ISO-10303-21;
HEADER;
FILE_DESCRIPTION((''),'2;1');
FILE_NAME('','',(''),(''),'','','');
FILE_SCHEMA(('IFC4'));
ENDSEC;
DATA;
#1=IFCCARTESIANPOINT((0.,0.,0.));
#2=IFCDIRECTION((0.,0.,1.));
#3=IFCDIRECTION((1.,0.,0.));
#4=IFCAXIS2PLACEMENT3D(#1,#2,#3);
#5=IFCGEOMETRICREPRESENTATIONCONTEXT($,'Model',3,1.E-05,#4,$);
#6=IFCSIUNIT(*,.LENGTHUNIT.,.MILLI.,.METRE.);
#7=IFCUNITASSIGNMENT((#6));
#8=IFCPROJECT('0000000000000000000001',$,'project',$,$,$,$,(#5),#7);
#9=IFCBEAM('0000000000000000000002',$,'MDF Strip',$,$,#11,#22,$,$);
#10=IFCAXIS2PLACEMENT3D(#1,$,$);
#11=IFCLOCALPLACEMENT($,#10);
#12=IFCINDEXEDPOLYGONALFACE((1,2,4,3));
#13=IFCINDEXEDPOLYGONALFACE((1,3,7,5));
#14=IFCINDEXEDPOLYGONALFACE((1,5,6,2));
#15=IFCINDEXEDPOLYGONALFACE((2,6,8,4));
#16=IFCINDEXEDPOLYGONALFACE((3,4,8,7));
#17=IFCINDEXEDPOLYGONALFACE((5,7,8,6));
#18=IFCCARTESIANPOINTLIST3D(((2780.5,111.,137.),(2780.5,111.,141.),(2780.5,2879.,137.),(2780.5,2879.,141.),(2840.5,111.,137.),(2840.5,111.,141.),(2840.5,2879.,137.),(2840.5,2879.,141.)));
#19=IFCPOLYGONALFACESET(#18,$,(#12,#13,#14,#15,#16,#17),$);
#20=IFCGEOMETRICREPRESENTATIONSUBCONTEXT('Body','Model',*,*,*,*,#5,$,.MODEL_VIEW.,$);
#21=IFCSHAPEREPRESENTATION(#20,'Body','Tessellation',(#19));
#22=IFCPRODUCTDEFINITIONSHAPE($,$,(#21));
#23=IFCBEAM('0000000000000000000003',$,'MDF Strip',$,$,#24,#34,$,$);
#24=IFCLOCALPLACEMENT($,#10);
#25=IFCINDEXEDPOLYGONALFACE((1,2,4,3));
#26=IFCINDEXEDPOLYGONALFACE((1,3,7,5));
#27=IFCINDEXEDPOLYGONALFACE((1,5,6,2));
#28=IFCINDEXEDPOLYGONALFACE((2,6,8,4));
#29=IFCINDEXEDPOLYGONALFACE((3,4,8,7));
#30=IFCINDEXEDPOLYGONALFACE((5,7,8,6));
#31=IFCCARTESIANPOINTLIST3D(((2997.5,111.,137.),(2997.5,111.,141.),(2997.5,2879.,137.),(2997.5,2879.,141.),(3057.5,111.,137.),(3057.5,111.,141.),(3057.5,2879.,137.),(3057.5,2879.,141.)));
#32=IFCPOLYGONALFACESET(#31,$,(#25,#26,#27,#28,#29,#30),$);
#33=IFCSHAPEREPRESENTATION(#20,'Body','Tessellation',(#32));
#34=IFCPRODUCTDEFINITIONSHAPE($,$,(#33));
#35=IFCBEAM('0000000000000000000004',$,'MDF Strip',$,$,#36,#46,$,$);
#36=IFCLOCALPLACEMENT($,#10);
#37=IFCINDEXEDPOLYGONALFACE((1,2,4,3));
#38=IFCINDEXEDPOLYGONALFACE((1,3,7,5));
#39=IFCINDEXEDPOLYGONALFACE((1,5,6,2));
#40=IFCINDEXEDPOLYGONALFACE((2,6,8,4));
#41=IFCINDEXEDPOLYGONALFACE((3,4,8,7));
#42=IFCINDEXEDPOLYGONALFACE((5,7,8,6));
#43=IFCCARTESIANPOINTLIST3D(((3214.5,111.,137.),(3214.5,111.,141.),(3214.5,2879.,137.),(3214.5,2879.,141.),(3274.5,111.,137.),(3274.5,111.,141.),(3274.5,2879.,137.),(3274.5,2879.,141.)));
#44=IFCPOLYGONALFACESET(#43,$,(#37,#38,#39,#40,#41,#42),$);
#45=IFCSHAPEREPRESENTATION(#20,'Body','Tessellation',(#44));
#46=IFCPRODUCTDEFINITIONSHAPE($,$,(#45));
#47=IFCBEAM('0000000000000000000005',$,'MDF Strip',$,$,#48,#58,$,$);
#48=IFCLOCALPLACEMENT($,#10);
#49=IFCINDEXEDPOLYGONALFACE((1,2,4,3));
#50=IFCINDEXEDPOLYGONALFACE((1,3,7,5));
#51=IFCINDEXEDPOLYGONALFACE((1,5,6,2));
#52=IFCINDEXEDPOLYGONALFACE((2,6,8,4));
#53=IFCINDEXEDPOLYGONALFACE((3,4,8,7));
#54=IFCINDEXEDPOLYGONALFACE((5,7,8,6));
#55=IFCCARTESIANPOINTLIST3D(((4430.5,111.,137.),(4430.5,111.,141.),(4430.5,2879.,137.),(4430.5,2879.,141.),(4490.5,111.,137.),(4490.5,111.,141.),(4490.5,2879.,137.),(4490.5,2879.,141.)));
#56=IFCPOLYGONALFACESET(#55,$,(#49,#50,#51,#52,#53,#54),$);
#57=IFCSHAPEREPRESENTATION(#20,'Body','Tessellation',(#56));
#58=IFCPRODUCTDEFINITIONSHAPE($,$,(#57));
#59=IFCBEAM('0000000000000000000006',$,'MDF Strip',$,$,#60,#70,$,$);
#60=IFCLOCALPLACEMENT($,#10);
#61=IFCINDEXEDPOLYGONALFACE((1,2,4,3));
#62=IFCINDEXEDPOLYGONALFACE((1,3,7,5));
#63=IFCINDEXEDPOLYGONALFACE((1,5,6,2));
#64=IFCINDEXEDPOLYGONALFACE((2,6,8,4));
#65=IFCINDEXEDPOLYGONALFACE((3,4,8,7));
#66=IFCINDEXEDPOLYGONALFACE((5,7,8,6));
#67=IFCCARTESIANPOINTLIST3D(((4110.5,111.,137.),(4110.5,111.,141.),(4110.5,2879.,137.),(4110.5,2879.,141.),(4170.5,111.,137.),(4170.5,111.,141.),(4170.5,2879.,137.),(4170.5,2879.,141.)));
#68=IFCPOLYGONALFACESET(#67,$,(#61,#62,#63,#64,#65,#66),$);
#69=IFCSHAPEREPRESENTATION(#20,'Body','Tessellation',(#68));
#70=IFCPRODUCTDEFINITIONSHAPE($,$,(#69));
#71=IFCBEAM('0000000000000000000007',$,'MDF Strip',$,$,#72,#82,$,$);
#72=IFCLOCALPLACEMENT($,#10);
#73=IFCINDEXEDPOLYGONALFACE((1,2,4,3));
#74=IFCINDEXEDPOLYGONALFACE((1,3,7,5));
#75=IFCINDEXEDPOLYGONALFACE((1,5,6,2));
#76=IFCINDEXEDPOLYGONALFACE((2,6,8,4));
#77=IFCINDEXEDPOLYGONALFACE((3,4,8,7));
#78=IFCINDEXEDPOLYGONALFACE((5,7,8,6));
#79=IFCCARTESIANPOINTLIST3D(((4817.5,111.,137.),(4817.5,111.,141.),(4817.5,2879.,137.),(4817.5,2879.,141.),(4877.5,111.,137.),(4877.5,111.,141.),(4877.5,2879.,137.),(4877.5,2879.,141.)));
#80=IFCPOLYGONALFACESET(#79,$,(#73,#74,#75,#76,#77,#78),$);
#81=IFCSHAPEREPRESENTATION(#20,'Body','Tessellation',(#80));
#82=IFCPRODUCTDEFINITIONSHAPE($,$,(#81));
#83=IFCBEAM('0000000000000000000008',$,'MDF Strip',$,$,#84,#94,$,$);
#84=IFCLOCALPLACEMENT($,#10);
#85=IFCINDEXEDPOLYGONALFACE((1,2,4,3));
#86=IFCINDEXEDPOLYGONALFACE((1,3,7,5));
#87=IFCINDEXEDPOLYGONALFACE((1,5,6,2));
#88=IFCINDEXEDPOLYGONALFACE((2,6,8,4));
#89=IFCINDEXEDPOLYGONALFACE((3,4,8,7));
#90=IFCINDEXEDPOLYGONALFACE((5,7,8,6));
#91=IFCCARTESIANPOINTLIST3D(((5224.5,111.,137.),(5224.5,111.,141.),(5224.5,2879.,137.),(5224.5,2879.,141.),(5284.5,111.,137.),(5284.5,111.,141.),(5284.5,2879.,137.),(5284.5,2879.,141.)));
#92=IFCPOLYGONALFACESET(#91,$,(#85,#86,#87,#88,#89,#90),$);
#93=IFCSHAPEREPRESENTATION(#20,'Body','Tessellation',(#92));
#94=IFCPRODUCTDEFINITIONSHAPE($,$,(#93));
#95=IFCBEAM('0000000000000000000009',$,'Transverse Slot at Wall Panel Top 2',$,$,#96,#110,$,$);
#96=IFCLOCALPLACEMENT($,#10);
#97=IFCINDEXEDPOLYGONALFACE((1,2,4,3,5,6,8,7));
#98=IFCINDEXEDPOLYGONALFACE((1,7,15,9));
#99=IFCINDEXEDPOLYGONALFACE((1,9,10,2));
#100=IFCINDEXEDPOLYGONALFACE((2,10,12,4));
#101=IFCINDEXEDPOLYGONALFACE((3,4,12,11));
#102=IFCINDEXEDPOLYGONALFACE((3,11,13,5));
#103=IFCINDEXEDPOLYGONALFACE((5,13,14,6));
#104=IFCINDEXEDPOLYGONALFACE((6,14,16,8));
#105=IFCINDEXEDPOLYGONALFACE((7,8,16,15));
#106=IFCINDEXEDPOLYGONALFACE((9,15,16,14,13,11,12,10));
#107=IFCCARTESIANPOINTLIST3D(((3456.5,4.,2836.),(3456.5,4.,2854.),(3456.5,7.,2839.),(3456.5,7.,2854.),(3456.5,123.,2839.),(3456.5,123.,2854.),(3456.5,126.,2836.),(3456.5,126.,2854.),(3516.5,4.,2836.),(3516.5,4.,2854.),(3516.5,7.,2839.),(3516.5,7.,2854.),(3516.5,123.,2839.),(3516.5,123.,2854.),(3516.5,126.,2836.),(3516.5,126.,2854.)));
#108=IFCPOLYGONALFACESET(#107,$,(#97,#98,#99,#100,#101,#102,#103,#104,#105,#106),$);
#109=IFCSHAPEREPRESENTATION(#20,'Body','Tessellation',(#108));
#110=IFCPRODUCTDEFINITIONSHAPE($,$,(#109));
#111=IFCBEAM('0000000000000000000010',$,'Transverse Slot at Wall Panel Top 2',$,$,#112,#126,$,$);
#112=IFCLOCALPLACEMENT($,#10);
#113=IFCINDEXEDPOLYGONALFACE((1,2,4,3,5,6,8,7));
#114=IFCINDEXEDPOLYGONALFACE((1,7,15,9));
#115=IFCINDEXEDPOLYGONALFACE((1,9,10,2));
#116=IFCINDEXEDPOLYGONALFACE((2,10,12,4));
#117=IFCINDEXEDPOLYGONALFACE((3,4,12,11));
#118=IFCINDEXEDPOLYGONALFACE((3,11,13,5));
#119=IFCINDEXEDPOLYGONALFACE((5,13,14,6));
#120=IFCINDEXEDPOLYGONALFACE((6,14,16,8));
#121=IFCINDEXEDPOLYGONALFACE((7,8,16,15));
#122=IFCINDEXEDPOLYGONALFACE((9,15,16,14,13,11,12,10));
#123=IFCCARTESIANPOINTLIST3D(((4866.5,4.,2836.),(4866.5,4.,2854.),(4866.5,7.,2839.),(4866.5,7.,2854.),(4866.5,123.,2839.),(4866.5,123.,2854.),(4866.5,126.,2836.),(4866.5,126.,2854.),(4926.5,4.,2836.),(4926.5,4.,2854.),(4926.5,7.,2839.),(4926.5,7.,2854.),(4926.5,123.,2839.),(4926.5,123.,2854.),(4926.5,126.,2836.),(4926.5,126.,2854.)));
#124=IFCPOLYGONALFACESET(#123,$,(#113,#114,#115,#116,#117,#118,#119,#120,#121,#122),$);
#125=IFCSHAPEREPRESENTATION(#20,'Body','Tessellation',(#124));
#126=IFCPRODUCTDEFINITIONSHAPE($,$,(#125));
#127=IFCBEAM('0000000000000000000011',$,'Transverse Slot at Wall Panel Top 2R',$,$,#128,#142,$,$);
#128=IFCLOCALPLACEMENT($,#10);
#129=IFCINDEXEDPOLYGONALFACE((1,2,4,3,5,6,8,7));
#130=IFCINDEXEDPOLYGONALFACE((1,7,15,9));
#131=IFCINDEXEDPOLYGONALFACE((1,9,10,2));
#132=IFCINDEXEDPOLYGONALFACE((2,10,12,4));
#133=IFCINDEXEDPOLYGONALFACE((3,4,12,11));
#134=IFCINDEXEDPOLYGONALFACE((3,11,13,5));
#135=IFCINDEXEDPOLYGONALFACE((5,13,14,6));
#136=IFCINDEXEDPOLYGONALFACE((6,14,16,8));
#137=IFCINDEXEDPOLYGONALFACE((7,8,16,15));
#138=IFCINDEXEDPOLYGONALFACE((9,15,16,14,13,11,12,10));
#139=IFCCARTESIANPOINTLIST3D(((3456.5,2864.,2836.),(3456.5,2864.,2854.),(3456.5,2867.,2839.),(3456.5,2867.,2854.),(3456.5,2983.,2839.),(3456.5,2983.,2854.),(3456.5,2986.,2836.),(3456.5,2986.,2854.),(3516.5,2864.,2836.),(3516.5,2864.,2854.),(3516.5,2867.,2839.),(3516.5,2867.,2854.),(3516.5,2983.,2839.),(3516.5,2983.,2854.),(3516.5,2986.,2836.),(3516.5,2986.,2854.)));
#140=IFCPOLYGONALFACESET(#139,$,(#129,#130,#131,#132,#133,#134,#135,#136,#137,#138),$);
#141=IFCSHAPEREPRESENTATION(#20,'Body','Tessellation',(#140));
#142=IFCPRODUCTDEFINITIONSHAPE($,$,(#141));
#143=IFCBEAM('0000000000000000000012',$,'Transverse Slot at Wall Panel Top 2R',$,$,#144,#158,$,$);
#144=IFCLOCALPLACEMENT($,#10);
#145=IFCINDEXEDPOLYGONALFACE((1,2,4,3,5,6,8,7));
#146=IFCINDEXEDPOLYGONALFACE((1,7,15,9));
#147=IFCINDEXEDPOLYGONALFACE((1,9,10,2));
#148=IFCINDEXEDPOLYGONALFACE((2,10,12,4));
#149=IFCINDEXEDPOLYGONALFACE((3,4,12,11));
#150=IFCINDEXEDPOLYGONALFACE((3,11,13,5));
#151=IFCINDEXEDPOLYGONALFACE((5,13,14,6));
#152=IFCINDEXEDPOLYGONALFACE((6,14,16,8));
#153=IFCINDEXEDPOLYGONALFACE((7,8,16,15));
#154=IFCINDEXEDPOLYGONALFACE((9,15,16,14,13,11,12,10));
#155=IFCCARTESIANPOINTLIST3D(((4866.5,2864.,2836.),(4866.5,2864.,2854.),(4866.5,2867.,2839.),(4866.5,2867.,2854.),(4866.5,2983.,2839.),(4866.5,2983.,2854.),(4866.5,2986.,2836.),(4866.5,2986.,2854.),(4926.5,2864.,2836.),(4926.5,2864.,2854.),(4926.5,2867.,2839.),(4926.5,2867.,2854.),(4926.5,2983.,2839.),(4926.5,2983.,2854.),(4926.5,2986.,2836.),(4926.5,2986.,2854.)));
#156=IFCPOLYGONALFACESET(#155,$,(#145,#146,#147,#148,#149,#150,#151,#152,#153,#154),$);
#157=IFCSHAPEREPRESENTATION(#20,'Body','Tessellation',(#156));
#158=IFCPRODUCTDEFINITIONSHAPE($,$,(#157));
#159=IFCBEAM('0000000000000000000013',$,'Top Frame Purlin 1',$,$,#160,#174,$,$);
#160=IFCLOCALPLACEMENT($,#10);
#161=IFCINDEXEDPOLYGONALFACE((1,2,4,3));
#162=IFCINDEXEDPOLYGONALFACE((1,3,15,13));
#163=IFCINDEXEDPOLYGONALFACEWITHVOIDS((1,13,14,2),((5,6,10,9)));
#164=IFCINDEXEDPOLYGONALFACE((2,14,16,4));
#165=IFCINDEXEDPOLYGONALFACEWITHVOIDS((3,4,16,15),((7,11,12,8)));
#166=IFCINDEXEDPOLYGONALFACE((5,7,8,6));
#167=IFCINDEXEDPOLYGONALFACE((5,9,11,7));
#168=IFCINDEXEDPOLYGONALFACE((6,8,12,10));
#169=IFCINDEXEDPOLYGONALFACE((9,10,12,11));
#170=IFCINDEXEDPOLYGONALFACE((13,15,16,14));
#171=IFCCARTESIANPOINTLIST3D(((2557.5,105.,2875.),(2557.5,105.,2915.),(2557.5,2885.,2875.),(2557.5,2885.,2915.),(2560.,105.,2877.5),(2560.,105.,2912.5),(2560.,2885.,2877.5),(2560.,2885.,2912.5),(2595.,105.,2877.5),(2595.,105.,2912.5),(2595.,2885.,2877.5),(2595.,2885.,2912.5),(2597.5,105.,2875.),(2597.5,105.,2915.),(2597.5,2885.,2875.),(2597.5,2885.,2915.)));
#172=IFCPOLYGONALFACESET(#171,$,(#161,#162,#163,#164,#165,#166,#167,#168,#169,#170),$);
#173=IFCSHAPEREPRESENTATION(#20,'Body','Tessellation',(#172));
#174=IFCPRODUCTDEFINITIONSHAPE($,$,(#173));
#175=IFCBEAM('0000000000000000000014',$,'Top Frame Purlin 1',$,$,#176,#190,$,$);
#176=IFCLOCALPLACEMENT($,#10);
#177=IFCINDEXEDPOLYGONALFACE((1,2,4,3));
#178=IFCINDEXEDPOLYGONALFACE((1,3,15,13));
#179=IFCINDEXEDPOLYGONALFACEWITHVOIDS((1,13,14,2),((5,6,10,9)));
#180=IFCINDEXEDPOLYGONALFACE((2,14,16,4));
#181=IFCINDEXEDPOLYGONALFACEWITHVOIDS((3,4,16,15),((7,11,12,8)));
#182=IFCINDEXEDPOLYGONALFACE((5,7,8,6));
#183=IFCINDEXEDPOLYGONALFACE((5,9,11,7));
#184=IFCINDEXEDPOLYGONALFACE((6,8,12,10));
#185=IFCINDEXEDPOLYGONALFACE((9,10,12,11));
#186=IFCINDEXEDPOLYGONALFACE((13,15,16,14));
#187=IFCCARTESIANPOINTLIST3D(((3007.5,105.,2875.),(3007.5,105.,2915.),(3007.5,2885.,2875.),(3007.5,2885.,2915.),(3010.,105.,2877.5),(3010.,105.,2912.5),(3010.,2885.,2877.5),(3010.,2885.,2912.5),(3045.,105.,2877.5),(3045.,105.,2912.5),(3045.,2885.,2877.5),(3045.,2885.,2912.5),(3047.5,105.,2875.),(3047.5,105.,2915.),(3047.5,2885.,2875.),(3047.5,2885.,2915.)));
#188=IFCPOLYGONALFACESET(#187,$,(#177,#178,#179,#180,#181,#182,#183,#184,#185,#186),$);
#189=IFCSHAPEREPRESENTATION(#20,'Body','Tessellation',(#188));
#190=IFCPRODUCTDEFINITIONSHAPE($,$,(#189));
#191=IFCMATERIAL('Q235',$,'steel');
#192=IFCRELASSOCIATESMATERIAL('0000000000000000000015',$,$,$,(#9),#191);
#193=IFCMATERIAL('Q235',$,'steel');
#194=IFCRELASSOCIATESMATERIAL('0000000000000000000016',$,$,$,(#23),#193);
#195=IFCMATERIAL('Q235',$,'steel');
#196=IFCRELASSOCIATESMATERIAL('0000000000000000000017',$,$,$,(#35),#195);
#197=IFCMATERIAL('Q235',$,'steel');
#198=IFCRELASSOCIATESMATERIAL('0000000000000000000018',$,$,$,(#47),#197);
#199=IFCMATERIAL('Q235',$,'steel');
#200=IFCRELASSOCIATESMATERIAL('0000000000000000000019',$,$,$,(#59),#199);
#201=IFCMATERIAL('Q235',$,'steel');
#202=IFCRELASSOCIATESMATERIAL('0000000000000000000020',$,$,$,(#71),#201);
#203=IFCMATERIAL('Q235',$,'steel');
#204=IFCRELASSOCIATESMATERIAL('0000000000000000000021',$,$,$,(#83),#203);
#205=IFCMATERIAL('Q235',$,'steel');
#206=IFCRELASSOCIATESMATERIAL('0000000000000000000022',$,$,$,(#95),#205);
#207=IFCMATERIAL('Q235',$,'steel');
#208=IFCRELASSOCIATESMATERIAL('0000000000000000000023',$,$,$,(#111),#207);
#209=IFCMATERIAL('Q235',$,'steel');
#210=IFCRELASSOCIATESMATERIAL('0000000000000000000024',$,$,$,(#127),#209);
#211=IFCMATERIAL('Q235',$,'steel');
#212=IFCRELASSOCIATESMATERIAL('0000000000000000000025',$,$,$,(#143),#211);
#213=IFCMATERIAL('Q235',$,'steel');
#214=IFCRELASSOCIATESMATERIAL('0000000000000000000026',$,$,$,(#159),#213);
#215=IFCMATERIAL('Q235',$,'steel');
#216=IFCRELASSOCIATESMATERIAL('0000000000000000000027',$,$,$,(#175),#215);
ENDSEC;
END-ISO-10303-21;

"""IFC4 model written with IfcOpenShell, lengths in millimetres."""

from ifc_helpers import new_model, si_unit, frame, origin_with_axes, place, context, subcontext, project, line, indexed_curve, outline, extrude, material, element, save


model = new_model("IFC4")

# Units and contexts
model_context = context("Model", 3, precision=1e-05, world=origin_with_axes())
body_context = subcontext(model_context, "Body", "Model", "MODEL_VIEW")
ifc_project = project(units=[si_unit("LENGTHUNIT", "METRE", prefix="MILLI")], contexts=[model_context])

# Beams
ifc_material_1 = material(Name="Q235", Category="steel")
beam_1_placement = place(None, frame((2780.5, 111.0, 137.0), z_axis=(0.0, 1.0, 0.0), x_axis=(1.0, 0.0, 0.0)))
element("IfcBeam", 1, at=beam_1_placement, material=ifc_material_1, Name="MDF Strip", context=body_context, shape_type="SweptSolid", body=[
    extrude(outline(indexed_curve([(0.0, 0.0), (60.0, 0.0), (60.0, -4.0), (0.0, -4.0), (0.0, 0.0)], segments=[line(1, 2, 3, 4, 5, 1)])), origin_with_axes(), (0.0, 0.0, 1.0), 2768.0),
])
ifc_material_2 = material(Name="Q235", Category="steel")
beam_2_placement = place(None, frame((2997.5, 111.0, 137.0), z_axis=(0.0, 1.0, 0.0), x_axis=(1.0, 0.0, 0.0)))
element("IfcBeam", 2, at=beam_2_placement, material=ifc_material_2, Name="MDF Strip", context=body_context, shape_type="SweptSolid", body=[
    extrude(outline(indexed_curve([(0.0, 0.0), (60.0, 0.0), (60.0, -4.0), (0.0, -4.0), (0.0, 0.0)], segments=[line(1, 2, 3, 4, 5, 1)])), origin_with_axes(), (0.0, 0.0, 1.0), 2768.0),
])
ifc_material_3 = material(Name="Q235", Category="steel")
beam_3_placement = place(None, frame((3214.5, 111.0, 137.0), z_axis=(0.0, 1.0, 0.0), x_axis=(1.0, 0.0, 0.0)))
element("IfcBeam", 3, at=beam_3_placement, material=ifc_material_3, Name="MDF Strip", context=body_context, shape_type="SweptSolid", body=[
    extrude(outline(indexed_curve([(0.0, 0.0), (60.0, 0.0), (60.0, -4.0), (0.0, -4.0), (0.0, 0.0)], segments=[line(1, 2, 3, 4, 5, 1)])), origin_with_axes(), (0.0, 0.0, 1.0), 2768.0),
])
ifc_material_4 = material(Name="Q235", Category="steel")
beam_4_placement = place(None, frame((4430.5, 111.0, 137.0), z_axis=(0.0, 1.0, 0.0), x_axis=(1.0, 0.0, 0.0)))
element("IfcBeam", 4, at=beam_4_placement, material=ifc_material_4, Name="MDF Strip", context=body_context, shape_type="SweptSolid", body=[
    extrude(outline(indexed_curve([(0.0, 0.0), (60.0, 0.0), (60.0, -4.0), (0.0, -4.0), (0.0, 0.0)], segments=[line(1, 2, 3, 4, 5, 1)])), origin_with_axes(), (0.0, 0.0, 1.0), 2768.0),
])
ifc_material_5 = material(Name="Q235", Category="steel")
beam_5_placement = place(None, frame((4110.5, 111.0, 137.0), z_axis=(0.0, 1.0, 0.0), x_axis=(1.0, 0.0, 0.0)))
element("IfcBeam", 5, at=beam_5_placement, material=ifc_material_5, Name="MDF Strip", context=body_context, shape_type="SweptSolid", body=[
    extrude(outline(indexed_curve([(0.0, 0.0), (60.0, 0.0), (60.0, -4.0), (0.0, -4.0), (0.0, 0.0)], segments=[line(1, 2, 3, 4, 5, 1)])), origin_with_axes(), (0.0, 0.0, 1.0), 2768.0),
])
ifc_material_6 = material(Name="Q235", Category="steel")
beam_6_placement = place(None, frame((4817.5, 111.0, 137.0), z_axis=(0.0, 1.0, 0.0), x_axis=(1.0, 0.0, 0.0)))
element("IfcBeam", 6, at=beam_6_placement, material=ifc_material_6, Name="MDF Strip", context=body_context, shape_type="SweptSolid", body=[
    extrude(outline(indexed_curve([(0.0, 0.0), (60.0, 0.0), (60.0, -4.0), (0.0, -4.0), (0.0, 0.0)], segments=[line(1, 2, 3, 4, 5, 1)])), origin_with_axes(), (0.0, 0.0, 1.0), 2768.0),
])
ifc_material_7 = material(Name="Q235", Category="steel")
beam_7_placement = place(None, frame((5224.5, 111.0, 137.0), z_axis=(0.0, 1.0, 0.0), x_axis=(1.0, 0.0, 0.0)))
element("IfcBeam", 7, at=beam_7_placement, material=ifc_material_7, Name="MDF Strip", context=body_context, shape_type="SweptSolid", body=[
    extrude(outline(indexed_curve([(0.0, 0.0), (60.0, 0.0), (60.0, -4.0), (0.0, -4.0), (0.0, 0.0)], segments=[line(1, 2, 3, 4, 5, 1)])), origin_with_axes(), (0.0, 0.0, 1.0), 2768.0),
])
ifc_material_8 = material(Name="Q235", Category="steel")
beam_8_placement = place(None, frame((3456.5, 4.0, 2836.0), z_axis=(1.0, 0.0, 0.0), x_axis=(0.0, 0.0, -1.0)))
element("IfcBeam", 8, at=beam_8_placement, material=ifc_material_8, Name="Transverse Slot at Wall Panel Top 2", context=body_context, shape_type="SweptSolid", body=[
    extrude(outline(indexed_curve([(0.0, 0.0), (0.0, 122.0), (-18.0, 122.0), (-18.0, 119.0), (-3.0, 119.0), (-3.0, 3.0), (-18.0, 3.0), (-18.0, 0.0), (0.0, 0.0)], segments=[line(1, 2, 3, 4, 5, 6, 7, 8, 9, 1)])), origin_with_axes(), (0.0, 0.0, 1.0), 60.0),
])
ifc_material_9 = material(Name="Q235", Category="steel")
beam_9_placement = place(None, frame((4866.5, 4.0, 2836.0), z_axis=(1.0, 0.0, 0.0), x_axis=(0.0, 0.0, -1.0)))
element("IfcBeam", 9, at=beam_9_placement, material=ifc_material_9, Name="Transverse Slot at Wall Panel Top 2", context=body_context, shape_type="SweptSolid", body=[
    extrude(outline(indexed_curve([(0.0, 0.0), (0.0, 122.0), (-18.0, 122.0), (-18.0, 119.0), (-3.0, 119.0), (-3.0, 3.0), (-18.0, 3.0), (-18.0, 0.0), (0.0, 0.0)], segments=[line(1, 2, 3, 4, 5, 6, 7, 8, 9, 1)])), origin_with_axes(), (0.0, 0.0, 1.0), 60.0),
])
ifc_material_10 = material(Name="Q235", Category="steel")
beam_10_placement = place(None, frame((3456.5, 2986.0, 2836.0), z_axis=(1.0, 0.0, 0.0), x_axis=(0.0, 0.0, 1.0)))
element("IfcBeam", 10, at=beam_10_placement, material=ifc_material_10, Name="Transverse Slot at Wall Panel Top 2R", context=body_context, shape_type="SweptSolid", body=[
    extrude(outline(indexed_curve([(0.0, 0.0), (0.0, 122.0), (18.0, 122.0), (18.0, 119.0), (3.0, 119.0), (3.0, 3.0), (18.0, 3.0), (18.0, 0.0), (0.0, 0.0)], segments=[line(1, 2, 3, 4, 5, 6, 7, 8, 9, 1)])), origin_with_axes(), (0.0, 0.0, 1.0), 60.0),
])
ifc_material_11 = material(Name="Q235", Category="steel")
beam_11_placement = place(None, frame((4866.5, 2986.0, 2836.0), z_axis=(1.0, 0.0, 0.0), x_axis=(0.0, 0.0, 1.0)))
element("IfcBeam", 11, at=beam_11_placement, material=ifc_material_11, Name="Transverse Slot at Wall Panel Top 2R", context=body_context, shape_type="SweptSolid", body=[
    extrude(outline(indexed_curve([(0.0, 0.0), (0.0, 122.0), (18.0, 122.0), (18.0, 119.0), (3.0, 119.0), (3.0, 3.0), (18.0, 3.0), (18.0, 0.0), (0.0, 0.0)], segments=[line(1, 2, 3, 4, 5, 6, 7, 8, 9, 1)])), origin_with_axes(), (0.0, 0.0, 1.0), 60.0),
])

# Beams, openings
ifc_material_12 = material(Name="Q235", Category="steel")
beam_12_placement = place(None, frame((2557.5, 105.0, 2875.0), z_axis=(0.0, 1.0, 0.0), x_axis=(1.0, 0.0, 0.0)))
beam_12 = element("IfcBeam", 12, at=beam_12_placement, material=ifc_material_12, Name="Top Frame Purlin 1", context=body_context, shape_type="SweptSolid", body=[
    extrude(outline(indexed_curve([(0.0, 0.0), (0.0, -40.0), (40.0, -40.0), (40.0, 0.0), (0.0, 0.0)], segments=[line(1, 2, 3, 4, 5, 1)])), origin_with_axes(), (0.0, 0.0, 1.0), 2780.0),
])
opening_1_placement = place(beam_12_placement, frame((2.5, -2.5, 0.0), z_axis=(0.0, 0.0, 1.0), x_axis=(1.0, 0.0, 0.0)))
element("IfcOpeningElement", 13, at=opening_1_placement, cuts=beam_12, context=body_context, shape_type="SweptSolid", body=[
    extrude(outline(indexed_curve([(0.0, 0.0), (0.0, -35.0), (35.0, -35.0), (35.0, 0.0)], segments=[line(1, 2, 3, 4, 1)])), origin_with_axes(), (0.0, 0.0, 1.0), 2780.0),
])
ifc_material_13 = material(Name="Q235", Category="steel")
beam_13_placement = place(None, frame((3007.5, 105.0, 2875.0), z_axis=(0.0, 1.0, 0.0), x_axis=(1.0, 0.0, 0.0)))
beam_13 = element("IfcBeam", 14, at=beam_13_placement, material=ifc_material_13, Name="Top Frame Purlin 1", context=body_context, shape_type="SweptSolid", body=[
    extrude(outline(indexed_curve([(0.0, 0.0), (0.0, -40.0), (40.0, -40.0), (40.0, 0.0), (0.0, 0.0)], segments=[line(1, 2, 3, 4, 5, 1)])), origin_with_axes(), (0.0, 0.0, 1.0), 2780.0),
])
opening_2_placement = place(beam_13_placement, frame((2.5, -2.5, 0.0), z_axis=(0.0, 0.0, 1.0), x_axis=(1.0, 0.0, 0.0)))
element("IfcOpeningElement", 15, at=opening_2_placement, cuts=beam_13, context=body_context, shape_type="SweptSolid", body=[
    extrude(outline(indexed_curve([(0.0, 0.0), (0.0, -35.0), (35.0, -35.0), (35.0, 0.0)], segments=[line(1, 2, 3, 4, 1)])), origin_with_axes(), (0.0, 0.0, 1.0), 2780.0),
])

save(model, "model.ifc")
